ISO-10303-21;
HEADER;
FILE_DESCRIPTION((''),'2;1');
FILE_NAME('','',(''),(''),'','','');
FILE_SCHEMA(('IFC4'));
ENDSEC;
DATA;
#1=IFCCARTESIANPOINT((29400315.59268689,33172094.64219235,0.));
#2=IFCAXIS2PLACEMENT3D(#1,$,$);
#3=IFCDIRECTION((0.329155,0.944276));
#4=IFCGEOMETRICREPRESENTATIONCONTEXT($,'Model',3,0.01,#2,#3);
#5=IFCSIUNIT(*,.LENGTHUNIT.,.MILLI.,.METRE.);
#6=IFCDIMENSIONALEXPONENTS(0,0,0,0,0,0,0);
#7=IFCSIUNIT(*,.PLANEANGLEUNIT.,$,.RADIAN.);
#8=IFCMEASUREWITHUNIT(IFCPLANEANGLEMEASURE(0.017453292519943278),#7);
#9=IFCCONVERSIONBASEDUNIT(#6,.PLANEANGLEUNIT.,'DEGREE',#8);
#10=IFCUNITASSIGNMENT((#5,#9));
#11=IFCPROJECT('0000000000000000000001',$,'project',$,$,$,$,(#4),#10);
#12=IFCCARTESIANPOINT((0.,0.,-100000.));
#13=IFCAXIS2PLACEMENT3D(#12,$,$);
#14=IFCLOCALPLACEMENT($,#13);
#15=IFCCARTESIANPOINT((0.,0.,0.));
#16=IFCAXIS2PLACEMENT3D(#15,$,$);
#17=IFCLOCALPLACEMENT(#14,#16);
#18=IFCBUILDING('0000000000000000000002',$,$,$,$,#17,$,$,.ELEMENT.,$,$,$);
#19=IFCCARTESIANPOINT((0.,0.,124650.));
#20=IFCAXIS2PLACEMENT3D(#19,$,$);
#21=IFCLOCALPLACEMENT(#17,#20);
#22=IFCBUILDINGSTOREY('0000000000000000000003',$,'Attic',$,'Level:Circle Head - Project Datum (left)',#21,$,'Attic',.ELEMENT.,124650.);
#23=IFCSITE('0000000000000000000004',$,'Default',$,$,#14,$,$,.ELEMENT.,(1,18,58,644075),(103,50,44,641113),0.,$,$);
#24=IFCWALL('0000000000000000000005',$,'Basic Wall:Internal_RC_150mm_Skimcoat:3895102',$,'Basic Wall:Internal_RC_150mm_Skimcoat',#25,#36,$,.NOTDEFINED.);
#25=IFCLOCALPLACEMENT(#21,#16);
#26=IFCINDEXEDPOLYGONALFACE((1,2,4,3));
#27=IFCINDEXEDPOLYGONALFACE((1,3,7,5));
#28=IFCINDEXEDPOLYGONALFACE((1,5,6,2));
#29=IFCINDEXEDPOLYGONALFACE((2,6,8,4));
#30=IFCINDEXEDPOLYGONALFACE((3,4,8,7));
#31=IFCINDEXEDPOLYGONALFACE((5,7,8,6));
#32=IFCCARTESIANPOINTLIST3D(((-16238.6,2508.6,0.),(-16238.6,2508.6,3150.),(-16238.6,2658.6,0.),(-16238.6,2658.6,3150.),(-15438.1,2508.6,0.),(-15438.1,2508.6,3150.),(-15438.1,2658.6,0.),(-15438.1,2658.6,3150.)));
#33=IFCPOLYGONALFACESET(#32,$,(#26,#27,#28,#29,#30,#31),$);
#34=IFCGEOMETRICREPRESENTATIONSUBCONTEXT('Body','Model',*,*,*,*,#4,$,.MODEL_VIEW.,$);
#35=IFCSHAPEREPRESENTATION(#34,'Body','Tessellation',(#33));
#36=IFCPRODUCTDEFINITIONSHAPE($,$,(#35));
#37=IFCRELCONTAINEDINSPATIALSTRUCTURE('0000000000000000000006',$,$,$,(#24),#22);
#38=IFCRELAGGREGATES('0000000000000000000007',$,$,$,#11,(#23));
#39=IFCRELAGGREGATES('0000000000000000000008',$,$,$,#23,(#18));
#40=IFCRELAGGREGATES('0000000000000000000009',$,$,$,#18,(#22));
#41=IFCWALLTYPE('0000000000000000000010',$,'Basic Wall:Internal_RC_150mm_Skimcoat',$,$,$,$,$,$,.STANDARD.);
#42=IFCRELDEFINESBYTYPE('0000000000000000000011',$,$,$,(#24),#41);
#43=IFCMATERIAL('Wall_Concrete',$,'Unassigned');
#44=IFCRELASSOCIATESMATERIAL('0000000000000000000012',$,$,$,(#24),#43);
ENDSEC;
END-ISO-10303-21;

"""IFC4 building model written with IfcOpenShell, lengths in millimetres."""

from ifc_helpers import new_model, entity, si_unit, converted_unit, direction, frame, origin, place, context, subcontext, project, spatial, indexed_curve, outline, extrude, material, type_object, element, save


model = new_model("IFC4")

# Units and contexts
model_context = context("Model", 3, precision=0.01, world=frame((29400315.59268689, 33172094.64219235, 0.0)), true_north=direction((0.329155, 0.944276)))
body_context = subcontext(model_context, "Body", "Model", "MODEL_VIEW")
ifc_project = project(units=[si_unit("LENGTHUNIT", "METRE", prefix="MILLI"), converted_unit("PLANEANGLEUNIT", "DEGREE", entity("IfcPlaneAngleMeasure", 0.017453292519943278), si_unit("PLANEANGLEUNIT", "RADIAN"), dimensions=[0, 0, 0, 0, 0, 0, 0])], contexts=[model_context])

# Site, building, storey
site_placement = place(None, frame((0.0, 0.0, -100000.0)))
site = spatial("IfcSite", under=ifc_project, at=site_placement, Name="Default", CompositionType="ELEMENT", RefLatitude=(1, 18, 58, 644075), RefLongitude=(103, 50, 44, 641113), RefElevation=0.0)
building_placement = place(site_placement, origin())
building = spatial("IfcBuilding", under=site, at=building_placement, CompositionType="ELEMENT")
storey_placement = place(building_placement, frame((0.0, 0.0, 124650.0)))
storey = spatial("IfcBuildingStorey", under=building, at=storey_placement, Name="Attic", ObjectType="Level:Circle Head - Project Datum (left)", LongName="Attic", CompositionType="ELEMENT", Elevation=124650.0)

# Wall
ifc_material_1 = material(Name="Wall_Concrete", Category="Unassigned")
wall_type_1 = type_object("IfcWallType", Name="Basic Wall:Internal_RC_150mm_Skimcoat", PredefinedType="STANDARD")
wall_1_placement = place(storey_placement, frame((-16238.6, 2583.6, 0.0)))
element("IfcWall", 1, at=wall_1_placement, inside=storey, type_object=wall_type_1, material=ifc_material_1, Name="Basic Wall:Internal_RC_150mm_Skimcoat:3895102", ObjectType="Basic Wall:Internal_RC_150mm_Skimcoat", PredefinedType="NOTDEFINED", context=body_context, shape_type="SweptSolid", body=[
    extrude(outline(indexed_curve([(800.5, 75.0), (0.0, 75.0), (0.0, -75.0), (800.5, -75.0), (800.5, 75.0)], self_intersect=False)), origin(), (0.0, 0.0, 1.0), 3150.0),
])

save(model, "model.ifc")
